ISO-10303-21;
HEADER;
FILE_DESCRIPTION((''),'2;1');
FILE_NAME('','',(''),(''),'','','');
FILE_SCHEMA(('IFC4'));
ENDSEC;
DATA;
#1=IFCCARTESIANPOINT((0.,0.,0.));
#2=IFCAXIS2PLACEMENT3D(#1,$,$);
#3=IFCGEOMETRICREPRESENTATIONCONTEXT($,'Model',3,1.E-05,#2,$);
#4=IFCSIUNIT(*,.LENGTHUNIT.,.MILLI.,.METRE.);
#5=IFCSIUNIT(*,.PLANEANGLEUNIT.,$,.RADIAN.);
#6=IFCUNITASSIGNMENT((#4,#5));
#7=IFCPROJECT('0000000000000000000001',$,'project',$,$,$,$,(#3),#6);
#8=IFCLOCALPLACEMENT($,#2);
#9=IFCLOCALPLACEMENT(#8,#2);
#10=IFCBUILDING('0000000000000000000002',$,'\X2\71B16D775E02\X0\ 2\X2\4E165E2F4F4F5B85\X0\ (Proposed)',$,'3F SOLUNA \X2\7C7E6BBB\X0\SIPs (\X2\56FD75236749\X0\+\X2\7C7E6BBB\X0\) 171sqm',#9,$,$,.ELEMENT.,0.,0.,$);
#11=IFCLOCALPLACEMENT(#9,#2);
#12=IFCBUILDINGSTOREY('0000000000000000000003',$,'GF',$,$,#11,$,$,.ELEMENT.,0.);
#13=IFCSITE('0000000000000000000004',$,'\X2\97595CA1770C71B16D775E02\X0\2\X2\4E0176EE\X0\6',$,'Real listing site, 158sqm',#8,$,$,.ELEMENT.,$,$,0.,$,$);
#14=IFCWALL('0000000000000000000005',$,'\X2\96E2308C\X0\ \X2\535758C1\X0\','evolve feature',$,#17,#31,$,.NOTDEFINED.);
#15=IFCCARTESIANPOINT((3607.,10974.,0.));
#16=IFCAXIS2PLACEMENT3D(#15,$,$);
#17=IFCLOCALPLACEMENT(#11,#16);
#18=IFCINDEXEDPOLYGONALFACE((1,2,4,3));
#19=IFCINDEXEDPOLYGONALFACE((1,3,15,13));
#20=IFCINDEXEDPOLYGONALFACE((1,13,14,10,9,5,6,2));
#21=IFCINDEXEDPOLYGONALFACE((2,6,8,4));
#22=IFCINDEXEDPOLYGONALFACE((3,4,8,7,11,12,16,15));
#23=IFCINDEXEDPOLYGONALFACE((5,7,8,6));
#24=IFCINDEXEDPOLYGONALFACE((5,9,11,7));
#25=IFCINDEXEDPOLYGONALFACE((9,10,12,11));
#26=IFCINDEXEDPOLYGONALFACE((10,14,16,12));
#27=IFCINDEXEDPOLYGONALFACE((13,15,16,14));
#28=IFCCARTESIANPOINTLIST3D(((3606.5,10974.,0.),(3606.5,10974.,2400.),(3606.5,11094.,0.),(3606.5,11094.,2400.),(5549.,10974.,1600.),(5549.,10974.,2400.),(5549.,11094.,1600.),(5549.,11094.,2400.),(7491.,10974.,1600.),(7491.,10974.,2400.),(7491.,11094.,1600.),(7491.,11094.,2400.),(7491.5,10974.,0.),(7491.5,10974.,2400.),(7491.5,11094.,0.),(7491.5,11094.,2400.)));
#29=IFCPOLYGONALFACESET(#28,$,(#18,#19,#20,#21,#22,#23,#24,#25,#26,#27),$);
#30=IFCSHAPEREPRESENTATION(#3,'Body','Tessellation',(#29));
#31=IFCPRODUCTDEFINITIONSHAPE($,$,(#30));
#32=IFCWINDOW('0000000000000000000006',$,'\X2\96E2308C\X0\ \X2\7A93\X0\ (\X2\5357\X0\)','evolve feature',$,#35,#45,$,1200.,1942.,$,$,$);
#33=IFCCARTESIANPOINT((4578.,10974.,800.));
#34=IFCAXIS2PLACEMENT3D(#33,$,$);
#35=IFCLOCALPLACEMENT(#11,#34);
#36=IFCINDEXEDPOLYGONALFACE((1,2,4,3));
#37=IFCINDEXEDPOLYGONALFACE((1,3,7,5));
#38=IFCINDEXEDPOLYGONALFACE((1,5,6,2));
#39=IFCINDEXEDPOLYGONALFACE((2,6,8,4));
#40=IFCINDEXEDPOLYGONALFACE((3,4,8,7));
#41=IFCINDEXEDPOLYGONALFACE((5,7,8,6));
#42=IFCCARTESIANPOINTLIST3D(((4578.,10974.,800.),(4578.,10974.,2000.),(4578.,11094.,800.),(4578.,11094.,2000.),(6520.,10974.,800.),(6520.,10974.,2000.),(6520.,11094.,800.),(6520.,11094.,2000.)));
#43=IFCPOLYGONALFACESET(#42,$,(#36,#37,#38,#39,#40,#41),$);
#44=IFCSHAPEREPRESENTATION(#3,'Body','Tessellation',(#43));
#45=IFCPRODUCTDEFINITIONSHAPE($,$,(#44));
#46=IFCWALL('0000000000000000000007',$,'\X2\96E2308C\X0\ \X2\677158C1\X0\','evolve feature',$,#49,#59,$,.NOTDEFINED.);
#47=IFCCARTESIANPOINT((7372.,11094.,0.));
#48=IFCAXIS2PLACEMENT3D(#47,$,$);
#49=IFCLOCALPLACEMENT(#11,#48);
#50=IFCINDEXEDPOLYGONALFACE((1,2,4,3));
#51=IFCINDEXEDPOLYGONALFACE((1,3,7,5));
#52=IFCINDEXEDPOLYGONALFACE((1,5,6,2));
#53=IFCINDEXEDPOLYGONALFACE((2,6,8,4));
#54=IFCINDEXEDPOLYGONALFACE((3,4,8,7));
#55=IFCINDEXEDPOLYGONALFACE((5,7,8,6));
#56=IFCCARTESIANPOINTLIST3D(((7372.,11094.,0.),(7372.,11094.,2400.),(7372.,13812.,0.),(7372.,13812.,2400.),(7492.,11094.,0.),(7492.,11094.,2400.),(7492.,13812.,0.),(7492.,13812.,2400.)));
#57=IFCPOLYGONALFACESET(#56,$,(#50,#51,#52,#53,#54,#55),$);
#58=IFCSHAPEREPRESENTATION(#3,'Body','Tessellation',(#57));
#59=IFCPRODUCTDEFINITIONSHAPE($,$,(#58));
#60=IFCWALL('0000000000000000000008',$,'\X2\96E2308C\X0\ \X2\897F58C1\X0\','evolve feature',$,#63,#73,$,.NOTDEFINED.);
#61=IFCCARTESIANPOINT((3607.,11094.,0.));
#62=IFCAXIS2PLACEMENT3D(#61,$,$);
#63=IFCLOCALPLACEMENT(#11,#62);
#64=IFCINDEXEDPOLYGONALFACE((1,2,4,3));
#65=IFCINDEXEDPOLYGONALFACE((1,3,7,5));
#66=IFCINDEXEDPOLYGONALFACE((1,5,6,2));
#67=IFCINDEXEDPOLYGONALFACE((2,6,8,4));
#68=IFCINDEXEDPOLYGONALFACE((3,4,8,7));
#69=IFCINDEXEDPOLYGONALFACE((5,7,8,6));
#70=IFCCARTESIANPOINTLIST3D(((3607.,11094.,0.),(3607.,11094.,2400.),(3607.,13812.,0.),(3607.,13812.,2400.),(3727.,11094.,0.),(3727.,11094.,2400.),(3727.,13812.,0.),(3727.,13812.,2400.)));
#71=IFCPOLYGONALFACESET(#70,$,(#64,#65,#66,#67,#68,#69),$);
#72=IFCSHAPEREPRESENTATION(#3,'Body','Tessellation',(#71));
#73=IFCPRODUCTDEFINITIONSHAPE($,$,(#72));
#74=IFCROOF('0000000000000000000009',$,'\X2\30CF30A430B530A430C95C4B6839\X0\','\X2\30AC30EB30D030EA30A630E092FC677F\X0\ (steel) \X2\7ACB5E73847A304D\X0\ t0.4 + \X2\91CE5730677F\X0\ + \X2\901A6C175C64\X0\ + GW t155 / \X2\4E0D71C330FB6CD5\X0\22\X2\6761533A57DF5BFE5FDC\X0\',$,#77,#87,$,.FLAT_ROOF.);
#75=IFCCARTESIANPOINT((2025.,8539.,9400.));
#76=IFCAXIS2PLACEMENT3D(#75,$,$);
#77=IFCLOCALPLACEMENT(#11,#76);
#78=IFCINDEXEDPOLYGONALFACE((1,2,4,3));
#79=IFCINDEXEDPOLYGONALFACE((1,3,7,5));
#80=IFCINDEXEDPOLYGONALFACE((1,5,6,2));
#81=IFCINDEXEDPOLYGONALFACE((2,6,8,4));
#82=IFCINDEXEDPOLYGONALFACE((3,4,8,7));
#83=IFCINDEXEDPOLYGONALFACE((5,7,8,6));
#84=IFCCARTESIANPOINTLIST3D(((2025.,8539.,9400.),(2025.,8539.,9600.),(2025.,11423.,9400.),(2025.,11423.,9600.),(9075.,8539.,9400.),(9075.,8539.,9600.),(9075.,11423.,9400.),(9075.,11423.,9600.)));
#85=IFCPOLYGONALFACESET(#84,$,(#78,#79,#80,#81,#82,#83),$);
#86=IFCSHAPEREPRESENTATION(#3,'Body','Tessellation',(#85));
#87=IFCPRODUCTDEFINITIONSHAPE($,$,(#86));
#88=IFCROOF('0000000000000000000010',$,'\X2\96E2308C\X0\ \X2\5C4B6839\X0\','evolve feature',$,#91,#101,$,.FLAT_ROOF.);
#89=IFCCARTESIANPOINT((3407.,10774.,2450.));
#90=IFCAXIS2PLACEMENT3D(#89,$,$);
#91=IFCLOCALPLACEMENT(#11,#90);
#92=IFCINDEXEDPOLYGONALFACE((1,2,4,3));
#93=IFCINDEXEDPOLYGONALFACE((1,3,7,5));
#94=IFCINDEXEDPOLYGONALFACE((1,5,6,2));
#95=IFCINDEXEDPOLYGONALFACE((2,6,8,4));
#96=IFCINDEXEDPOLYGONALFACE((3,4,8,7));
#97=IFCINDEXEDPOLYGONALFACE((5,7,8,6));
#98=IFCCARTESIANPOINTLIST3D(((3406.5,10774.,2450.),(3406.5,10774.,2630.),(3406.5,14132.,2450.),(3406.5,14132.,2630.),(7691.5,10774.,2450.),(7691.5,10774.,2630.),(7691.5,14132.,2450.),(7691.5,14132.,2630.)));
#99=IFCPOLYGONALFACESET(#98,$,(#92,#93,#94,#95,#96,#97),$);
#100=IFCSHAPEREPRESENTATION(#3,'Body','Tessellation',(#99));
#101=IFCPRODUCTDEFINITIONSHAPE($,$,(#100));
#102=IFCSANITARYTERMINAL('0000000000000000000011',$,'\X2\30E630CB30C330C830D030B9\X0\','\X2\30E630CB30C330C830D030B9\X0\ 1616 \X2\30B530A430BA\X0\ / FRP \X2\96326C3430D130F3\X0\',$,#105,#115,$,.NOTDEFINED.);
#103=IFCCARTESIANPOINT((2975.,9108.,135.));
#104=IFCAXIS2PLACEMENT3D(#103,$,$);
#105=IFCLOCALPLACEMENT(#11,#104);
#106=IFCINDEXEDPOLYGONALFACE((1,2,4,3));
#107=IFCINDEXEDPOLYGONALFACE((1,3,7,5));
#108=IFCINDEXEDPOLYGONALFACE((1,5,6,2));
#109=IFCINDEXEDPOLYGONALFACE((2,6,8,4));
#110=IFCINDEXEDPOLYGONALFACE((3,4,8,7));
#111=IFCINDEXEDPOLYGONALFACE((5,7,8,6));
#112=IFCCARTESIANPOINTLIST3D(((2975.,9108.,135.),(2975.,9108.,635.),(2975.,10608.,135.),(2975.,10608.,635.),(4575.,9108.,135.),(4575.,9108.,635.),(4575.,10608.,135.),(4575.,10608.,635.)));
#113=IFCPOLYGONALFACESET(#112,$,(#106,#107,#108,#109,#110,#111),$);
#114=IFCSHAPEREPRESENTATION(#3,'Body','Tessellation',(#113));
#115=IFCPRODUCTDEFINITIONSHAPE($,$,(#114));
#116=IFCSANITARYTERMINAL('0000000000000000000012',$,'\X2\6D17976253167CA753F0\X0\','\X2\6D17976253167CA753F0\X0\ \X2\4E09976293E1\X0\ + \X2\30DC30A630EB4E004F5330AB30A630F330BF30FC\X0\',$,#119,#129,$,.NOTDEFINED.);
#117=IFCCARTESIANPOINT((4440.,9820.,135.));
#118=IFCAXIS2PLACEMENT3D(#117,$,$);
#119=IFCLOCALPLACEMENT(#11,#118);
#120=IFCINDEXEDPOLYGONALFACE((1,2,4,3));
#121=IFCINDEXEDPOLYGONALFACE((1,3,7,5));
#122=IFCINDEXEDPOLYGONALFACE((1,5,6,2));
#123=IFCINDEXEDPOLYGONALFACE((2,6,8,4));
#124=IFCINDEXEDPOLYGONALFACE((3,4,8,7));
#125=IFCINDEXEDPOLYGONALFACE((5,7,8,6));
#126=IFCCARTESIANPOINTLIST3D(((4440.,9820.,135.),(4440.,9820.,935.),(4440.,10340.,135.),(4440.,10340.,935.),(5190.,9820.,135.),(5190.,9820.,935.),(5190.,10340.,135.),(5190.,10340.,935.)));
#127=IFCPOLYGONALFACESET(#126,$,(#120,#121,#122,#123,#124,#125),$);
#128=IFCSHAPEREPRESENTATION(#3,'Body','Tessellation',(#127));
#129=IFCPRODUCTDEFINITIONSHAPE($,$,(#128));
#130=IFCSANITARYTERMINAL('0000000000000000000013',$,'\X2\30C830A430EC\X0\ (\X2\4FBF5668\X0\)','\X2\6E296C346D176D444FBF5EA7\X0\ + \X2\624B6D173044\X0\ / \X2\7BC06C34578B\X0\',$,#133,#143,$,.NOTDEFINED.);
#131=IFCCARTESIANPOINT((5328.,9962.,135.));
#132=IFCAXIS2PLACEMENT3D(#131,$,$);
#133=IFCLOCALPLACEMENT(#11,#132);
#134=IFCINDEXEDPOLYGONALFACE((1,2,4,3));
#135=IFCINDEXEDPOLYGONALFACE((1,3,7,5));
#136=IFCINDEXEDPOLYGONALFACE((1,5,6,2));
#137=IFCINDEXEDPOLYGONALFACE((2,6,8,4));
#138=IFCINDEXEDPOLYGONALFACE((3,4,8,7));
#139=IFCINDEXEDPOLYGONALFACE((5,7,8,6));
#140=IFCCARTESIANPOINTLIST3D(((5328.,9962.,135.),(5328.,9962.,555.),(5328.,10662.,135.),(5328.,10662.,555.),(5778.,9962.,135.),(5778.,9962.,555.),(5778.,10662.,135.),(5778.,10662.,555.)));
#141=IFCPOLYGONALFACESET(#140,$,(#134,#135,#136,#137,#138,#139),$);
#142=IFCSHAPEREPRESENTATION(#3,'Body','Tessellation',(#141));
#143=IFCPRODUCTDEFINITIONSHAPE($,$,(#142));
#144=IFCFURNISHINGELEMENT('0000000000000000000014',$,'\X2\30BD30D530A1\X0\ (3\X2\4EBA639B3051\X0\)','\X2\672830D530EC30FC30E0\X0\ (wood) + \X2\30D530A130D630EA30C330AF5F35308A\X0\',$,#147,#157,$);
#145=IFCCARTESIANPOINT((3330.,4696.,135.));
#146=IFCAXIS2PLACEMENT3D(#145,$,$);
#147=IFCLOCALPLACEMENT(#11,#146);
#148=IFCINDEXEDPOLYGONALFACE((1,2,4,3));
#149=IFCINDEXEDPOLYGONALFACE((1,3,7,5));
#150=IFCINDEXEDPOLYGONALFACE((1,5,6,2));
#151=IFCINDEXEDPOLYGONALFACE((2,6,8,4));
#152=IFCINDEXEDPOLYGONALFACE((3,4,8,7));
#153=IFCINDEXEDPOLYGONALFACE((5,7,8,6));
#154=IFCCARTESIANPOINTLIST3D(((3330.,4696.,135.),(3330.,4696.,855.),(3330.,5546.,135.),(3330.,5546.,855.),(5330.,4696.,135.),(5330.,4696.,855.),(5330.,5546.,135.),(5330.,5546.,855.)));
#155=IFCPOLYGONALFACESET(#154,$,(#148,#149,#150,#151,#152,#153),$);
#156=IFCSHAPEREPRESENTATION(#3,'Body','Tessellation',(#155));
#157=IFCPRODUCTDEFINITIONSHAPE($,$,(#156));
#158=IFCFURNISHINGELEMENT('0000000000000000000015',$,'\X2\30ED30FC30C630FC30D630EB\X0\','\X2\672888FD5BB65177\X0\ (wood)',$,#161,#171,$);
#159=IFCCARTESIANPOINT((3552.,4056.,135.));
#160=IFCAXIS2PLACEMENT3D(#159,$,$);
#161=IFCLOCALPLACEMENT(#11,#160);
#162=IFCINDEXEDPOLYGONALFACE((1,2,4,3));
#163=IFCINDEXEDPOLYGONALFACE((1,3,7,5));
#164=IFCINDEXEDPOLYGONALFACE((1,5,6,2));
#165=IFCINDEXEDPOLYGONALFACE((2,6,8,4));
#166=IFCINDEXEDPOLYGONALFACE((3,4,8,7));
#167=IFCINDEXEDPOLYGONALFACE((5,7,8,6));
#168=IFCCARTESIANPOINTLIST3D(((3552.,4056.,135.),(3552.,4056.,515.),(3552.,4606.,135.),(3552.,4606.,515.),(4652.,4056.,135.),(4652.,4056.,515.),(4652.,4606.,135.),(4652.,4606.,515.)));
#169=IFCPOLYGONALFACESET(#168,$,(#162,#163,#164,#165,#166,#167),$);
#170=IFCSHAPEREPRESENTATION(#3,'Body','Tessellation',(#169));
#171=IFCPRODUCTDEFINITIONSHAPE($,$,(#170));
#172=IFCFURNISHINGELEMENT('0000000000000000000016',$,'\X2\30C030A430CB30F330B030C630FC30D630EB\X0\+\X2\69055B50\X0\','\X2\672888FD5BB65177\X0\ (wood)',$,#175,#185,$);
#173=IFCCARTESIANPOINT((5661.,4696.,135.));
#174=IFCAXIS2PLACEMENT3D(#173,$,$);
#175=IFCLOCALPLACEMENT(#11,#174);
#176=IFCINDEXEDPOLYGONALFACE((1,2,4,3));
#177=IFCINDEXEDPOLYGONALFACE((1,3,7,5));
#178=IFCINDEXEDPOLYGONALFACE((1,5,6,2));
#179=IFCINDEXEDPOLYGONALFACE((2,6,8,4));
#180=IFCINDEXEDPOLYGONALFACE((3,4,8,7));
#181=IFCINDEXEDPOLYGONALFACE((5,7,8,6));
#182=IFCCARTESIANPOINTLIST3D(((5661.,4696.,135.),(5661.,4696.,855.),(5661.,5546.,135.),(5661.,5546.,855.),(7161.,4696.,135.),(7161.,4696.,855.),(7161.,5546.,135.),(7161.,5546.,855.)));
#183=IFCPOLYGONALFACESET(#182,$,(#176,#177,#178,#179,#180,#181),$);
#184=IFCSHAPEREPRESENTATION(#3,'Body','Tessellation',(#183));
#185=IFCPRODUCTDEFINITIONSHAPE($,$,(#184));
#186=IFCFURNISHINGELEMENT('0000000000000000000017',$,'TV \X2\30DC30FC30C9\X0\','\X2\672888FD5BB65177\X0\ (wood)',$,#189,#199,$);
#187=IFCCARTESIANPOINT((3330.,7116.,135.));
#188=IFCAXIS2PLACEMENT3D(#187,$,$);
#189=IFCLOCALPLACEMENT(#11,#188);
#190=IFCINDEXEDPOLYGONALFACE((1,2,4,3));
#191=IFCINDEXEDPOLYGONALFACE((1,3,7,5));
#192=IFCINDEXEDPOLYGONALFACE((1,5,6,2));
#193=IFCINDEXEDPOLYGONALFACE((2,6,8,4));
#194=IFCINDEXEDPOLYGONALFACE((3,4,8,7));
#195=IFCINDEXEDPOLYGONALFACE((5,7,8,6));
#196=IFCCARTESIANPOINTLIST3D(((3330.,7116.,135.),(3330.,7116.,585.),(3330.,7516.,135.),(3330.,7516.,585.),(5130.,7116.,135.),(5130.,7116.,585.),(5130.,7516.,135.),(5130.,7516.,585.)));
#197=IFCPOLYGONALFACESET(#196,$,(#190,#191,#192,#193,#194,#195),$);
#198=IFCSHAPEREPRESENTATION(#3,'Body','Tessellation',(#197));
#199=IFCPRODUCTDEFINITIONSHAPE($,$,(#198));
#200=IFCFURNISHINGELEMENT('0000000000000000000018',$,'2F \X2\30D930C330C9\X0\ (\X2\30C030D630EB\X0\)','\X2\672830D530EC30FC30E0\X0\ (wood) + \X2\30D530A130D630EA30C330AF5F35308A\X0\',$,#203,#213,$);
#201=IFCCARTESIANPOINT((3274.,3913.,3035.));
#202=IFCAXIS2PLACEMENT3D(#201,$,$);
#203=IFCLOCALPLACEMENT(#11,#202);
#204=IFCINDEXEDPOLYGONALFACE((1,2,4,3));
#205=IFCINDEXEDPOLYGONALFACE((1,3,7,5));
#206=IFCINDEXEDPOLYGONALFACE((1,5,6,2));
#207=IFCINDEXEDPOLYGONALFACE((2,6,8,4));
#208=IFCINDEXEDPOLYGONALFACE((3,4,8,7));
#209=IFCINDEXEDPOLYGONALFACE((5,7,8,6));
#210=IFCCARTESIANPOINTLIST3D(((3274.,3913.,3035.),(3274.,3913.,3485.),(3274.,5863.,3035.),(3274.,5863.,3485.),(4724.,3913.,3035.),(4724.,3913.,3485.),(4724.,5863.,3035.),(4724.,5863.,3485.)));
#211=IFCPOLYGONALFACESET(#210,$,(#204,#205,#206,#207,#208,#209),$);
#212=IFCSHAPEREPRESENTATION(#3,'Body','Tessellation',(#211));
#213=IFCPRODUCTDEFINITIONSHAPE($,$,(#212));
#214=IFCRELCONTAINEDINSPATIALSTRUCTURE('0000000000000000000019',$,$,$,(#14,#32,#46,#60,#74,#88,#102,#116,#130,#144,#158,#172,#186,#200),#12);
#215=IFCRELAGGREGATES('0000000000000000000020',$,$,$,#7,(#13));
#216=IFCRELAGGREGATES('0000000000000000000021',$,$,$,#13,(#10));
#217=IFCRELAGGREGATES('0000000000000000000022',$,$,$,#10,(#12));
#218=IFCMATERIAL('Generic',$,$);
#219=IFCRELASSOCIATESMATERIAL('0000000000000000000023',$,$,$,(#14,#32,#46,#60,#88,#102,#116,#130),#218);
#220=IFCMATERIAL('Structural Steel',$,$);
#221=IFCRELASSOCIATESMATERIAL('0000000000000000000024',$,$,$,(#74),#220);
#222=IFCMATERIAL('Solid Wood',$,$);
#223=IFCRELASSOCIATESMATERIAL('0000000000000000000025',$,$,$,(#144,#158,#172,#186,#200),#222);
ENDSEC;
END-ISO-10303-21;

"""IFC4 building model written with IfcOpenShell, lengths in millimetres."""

from ifc_helpers import new_model, si_unit, frame, frame_2d, origin, place, context, project, spatial, rectangle, extrude, material, element, fill, save


model = new_model("IFC4")

# Units and contexts
model_context = context("Model", 3, precision=1e-05, world=origin())
ifc_project = project(units=[si_unit("LENGTHUNIT", "METRE", prefix="MILLI"), si_unit("PLANEANGLEUNIT", "RADIAN")], contexts=[model_context])

# Site, building, storey
site_placement = place(None, origin())
site = spatial("IfcSite", under=ifc_project, at=site_placement, Name="静岡県熱海市2丁目6", ObjectType="Real listing site, 158sqm", CompositionType="ELEMENT", RefElevation=0.0)
building_placement = place(site_placement, origin())
building = spatial("IfcBuilding", under=site, at=building_placement, Name="熱海市 2世帯住宅 (Proposed)", ObjectType="3F SOLUNA 籾殻SIPs (国産杉+籾殻) 171sqm", CompositionType="ELEMENT", ElevationOfRefHeight=0.0, ElevationOfTerrain=0.0)
storey_placement = place(building_placement, origin())
storey = spatial("IfcBuildingStorey", under=building, at=storey_placement, Name="GF", CompositionType="ELEMENT", Elevation=0.0)

# Shared definitions
ifc_material_1 = material(Name="Generic")

# Shared definitions
ifc_material_2 = material(Name="Solid Wood")

# Wall, opening, window
wall_1_placement = place(storey_placement, frame((3607.0, 10974.0, 0.0)))
wall_1 = element("IfcWall", 1, at=wall_1_placement, inside=storey, material=ifc_material_1, Name="離れ 南壁", Description="evolve feature", PredefinedType="NOTDEFINED", context=model_context, shape_type="SweptSolid", body=[
    extrude(rectangle(XDim=3885.0, YDim=120.0, at=frame_2d((1942.0, 60.0))), frame((3607.0, 10974.0, 0.0)), (0.0, 0.0, 1.0), 2400.0),
])
opening_1_placement = place(storey_placement, frame((4578.0, 10974.0, 800.0)))
opening_1 = element("IfcOpeningElement", 2, at=opening_1_placement, cuts=wall_1, PredefinedType="NOTDEFINED", context=model_context, shape_type="SweptSolid", body=[
    extrude(rectangle(XDim=1942.0, YDim=120.0, at=frame_2d((971.0, 60.0))), frame((4578.0, 10974.0, 800.0)), (0.0, 0.0, 1.0), 1200.0),
])
window_1_placement = place(storey_placement, frame((4578.0, 10974.0, 800.0)))
window_1 = element("IfcWindow", 3, at=window_1_placement, inside=storey, material=ifc_material_1, Name="離れ 窓 (南)", Description="evolve feature", OverallHeight=1200.0, OverallWidth=1942.0, context=model_context, shape_type="SweptSolid", body=[
    extrude(rectangle(XDim=1942.0, YDim=120.0, at=frame_2d((971.0, 60.0))), frame((4578.0, 10974.0, 800.0)), (0.0, 0.0, 1.0), 1200.0),
])
fill(opening_1, window_1)

# Walls
wall_2_placement = place(storey_placement, frame((7372.0, 11094.0, 0.0)))
element("IfcWall", 4, at=wall_2_placement, inside=storey, material=ifc_material_1, Name="離れ 東壁", Description="evolve feature", PredefinedType="NOTDEFINED", context=model_context, shape_type="SweptSolid", body=[
    extrude(rectangle(XDim=120.0, YDim=2718.0, at=frame_2d((60.0, 1359.0))), frame((7372.0, 11094.0, 0.0)), (0.0, 0.0, 1.0), 2400.0),
])
wall_3_placement = place(storey_placement, frame((3607.0, 11094.0, 0.0)))
element("IfcWall", 5, at=wall_3_placement, inside=storey, material=ifc_material_1, Name="離れ 西壁", Description="evolve feature", PredefinedType="NOTDEFINED", context=model_context, shape_type="SweptSolid", body=[
    extrude(rectangle(XDim=120.0, YDim=2718.0, at=frame_2d((60.0, 1359.0))), frame((3607.0, 11094.0, 0.0)), (0.0, 0.0, 1.0), 2400.0),
])

# Roofs
ifc_material_3 = material(Name="Structural Steel")
roof_1_placement = place(storey_placement, frame((2025.0, 8539.0, 9400.0)))
element("IfcRoof", 6, at=roof_1_placement, inside=storey, material=ifc_material_3, Name="ハイサイド屋根", Description="ガルバリウム鋼板 (steel) 立平葺き t0.4 + 野地板 + 通気層 + GW t155 / 不燃・法22条区域対応", PredefinedType="FLAT_ROOF", context=model_context, shape_type="SweptSolid", body=[
    extrude(rectangle(XDim=7050.0, YDim=2884.0, at=frame_2d((3525.0, 1442.0))), frame((2025.0, 8539.0, 9400.0)), (0.0, 0.0, 1.0), 200.0),
])
roof_2_placement = place(storey_placement, frame((3407.0, 10774.0, 2450.0)))
element("IfcRoof", 7, at=roof_2_placement, inside=storey, material=ifc_material_1, Name="離れ 屋根", Description="evolve feature", PredefinedType="FLAT_ROOF", context=model_context, shape_type="SweptSolid", body=[
    extrude(rectangle(XDim=4285.0, YDim=3358.0, at=frame_2d((2142.0, 1679.0))), frame((3407.0, 10774.0, 2450.0)), (0.0, 0.0, 1.0), 180.0),
])

# Sanitary terminals
sanitary_terminal_1_placement = place(storey_placement, frame((2975.0, 9108.0, 135.0)))
element("IfcSanitaryTerminal", 8, at=sanitary_terminal_1_placement, inside=storey, material=ifc_material_1, Name="ユニットバス", Description="ユニットバス 1616 サイズ / FRP 防水パン", PredefinedType="NOTDEFINED", context=model_context, shape_type="SweptSolid", body=[
    extrude(rectangle(XDim=1600.0, YDim=1500.0, at=frame_2d((800.0, 750.0))), frame((2975.0, 9108.0, 135.0)), (0.0, 0.0, 1.0), 500.0),
])
sanitary_terminal_2_placement = place(storey_placement, frame((4440.0, 9820.0, 135.0)))
element("IfcSanitaryTerminal", 9, at=sanitary_terminal_2_placement, inside=storey, material=ifc_material_1, Name="洗面化粧台", Description="洗面化粧台 三面鏡 + ボウル一体カウンター", PredefinedType="NOTDEFINED", context=model_context, shape_type="SweptSolid", body=[
    extrude(rectangle(XDim=750.0, YDim=520.0, at=frame_2d((375.0, 260.0))), frame((4440.0, 9820.0, 135.0)), (0.0, 0.0, 1.0), 800.0),
])
sanitary_terminal_3_placement = place(storey_placement, frame((5328.0, 9962.0, 135.0)))
element("IfcSanitaryTerminal", 10, at=sanitary_terminal_3_placement, inside=storey, material=ifc_material_1, Name="トイレ (便器)", Description="温水洗浄便座 + 手洗い / 節水型", PredefinedType="NOTDEFINED", context=model_context, shape_type="SweptSolid", body=[
    extrude(rectangle(XDim=450.0, YDim=700.0, at=frame_2d((225.0, 350.0))), frame((5328.0, 9962.0, 135.0)), (0.0, 0.0, 1.0), 420.0),
])

# Furnishing elements
furnishing_1_placement = place(storey_placement, frame((3330.0, 4696.0, 135.0)))
element("IfcFurnishingElement", 11, at=furnishing_1_placement, inside=storey, material=ifc_material_2, Name="ソファ (3人掛け)", Description="木フレーム (wood) + ファブリック張り", context=model_context, shape_type="SweptSolid", body=[
    extrude(rectangle(XDim=2000.0, YDim=850.0, at=frame_2d((1000.0, 425.0))), frame((3330.0, 4696.0, 135.0)), (0.0, 0.0, 1.0), 720.0),
])
furnishing_2_placement = place(storey_placement, frame((3552.0, 4056.0, 135.0)))
element("IfcFurnishingElement", 12, at=furnishing_2_placement, inside=storey, material=ifc_material_2, Name="ローテーブル", Description="木製家具 (wood)", context=model_context, shape_type="SweptSolid", body=[
    extrude(rectangle(XDim=1100.0, YDim=550.0, at=frame_2d((550.0, 275.0))), frame((3552.0, 4056.0, 135.0)), (0.0, 0.0, 1.0), 380.0),
])
furnishing_3_placement = place(storey_placement, frame((5661.0, 4696.0, 135.0)))
element("IfcFurnishingElement", 13, at=furnishing_3_placement, inside=storey, material=ifc_material_2, Name="ダイニングテーブル+椅子", Description="木製家具 (wood)", context=model_context, shape_type="SweptSolid", body=[
    extrude(rectangle(XDim=1500.0, YDim=850.0, at=frame_2d((750.0, 425.0))), frame((5661.0, 4696.0, 135.0)), (0.0, 0.0, 1.0), 720.0),
])
furnishing_4_placement = place(storey_placement, frame((3330.0, 7116.0, 135.0)))
element("IfcFurnishingElement", 14, at=furnishing_4_placement, inside=storey, material=ifc_material_2, Name="TV ボード", Description="木製家具 (wood)", context=model_context, shape_type="SweptSolid", body=[
    extrude(rectangle(XDim=1800.0, YDim=400.0, at=frame_2d((900.0, 200.0))), frame((3330.0, 7116.0, 135.0)), (0.0, 0.0, 1.0), 450.0),
])
furnishing_5_placement = place(storey_placement, frame((3274.0, 3913.0, 3035.0)))
element("IfcFurnishingElement", 15, at=furnishing_5_placement, inside=storey, material=ifc_material_2, Name="2F ベッド (ダブル)", Description="木フレーム (wood) + ファブリック張り", context=model_context, shape_type="SweptSolid", body=[
    extrude(rectangle(XDim=1450.0, YDim=1950.0, at=frame_2d((725.0, 975.0))), frame((3274.0, 3913.0, 3035.0)), (0.0, 0.0, 1.0), 450.0),
])

save(model, "model.ifc")
